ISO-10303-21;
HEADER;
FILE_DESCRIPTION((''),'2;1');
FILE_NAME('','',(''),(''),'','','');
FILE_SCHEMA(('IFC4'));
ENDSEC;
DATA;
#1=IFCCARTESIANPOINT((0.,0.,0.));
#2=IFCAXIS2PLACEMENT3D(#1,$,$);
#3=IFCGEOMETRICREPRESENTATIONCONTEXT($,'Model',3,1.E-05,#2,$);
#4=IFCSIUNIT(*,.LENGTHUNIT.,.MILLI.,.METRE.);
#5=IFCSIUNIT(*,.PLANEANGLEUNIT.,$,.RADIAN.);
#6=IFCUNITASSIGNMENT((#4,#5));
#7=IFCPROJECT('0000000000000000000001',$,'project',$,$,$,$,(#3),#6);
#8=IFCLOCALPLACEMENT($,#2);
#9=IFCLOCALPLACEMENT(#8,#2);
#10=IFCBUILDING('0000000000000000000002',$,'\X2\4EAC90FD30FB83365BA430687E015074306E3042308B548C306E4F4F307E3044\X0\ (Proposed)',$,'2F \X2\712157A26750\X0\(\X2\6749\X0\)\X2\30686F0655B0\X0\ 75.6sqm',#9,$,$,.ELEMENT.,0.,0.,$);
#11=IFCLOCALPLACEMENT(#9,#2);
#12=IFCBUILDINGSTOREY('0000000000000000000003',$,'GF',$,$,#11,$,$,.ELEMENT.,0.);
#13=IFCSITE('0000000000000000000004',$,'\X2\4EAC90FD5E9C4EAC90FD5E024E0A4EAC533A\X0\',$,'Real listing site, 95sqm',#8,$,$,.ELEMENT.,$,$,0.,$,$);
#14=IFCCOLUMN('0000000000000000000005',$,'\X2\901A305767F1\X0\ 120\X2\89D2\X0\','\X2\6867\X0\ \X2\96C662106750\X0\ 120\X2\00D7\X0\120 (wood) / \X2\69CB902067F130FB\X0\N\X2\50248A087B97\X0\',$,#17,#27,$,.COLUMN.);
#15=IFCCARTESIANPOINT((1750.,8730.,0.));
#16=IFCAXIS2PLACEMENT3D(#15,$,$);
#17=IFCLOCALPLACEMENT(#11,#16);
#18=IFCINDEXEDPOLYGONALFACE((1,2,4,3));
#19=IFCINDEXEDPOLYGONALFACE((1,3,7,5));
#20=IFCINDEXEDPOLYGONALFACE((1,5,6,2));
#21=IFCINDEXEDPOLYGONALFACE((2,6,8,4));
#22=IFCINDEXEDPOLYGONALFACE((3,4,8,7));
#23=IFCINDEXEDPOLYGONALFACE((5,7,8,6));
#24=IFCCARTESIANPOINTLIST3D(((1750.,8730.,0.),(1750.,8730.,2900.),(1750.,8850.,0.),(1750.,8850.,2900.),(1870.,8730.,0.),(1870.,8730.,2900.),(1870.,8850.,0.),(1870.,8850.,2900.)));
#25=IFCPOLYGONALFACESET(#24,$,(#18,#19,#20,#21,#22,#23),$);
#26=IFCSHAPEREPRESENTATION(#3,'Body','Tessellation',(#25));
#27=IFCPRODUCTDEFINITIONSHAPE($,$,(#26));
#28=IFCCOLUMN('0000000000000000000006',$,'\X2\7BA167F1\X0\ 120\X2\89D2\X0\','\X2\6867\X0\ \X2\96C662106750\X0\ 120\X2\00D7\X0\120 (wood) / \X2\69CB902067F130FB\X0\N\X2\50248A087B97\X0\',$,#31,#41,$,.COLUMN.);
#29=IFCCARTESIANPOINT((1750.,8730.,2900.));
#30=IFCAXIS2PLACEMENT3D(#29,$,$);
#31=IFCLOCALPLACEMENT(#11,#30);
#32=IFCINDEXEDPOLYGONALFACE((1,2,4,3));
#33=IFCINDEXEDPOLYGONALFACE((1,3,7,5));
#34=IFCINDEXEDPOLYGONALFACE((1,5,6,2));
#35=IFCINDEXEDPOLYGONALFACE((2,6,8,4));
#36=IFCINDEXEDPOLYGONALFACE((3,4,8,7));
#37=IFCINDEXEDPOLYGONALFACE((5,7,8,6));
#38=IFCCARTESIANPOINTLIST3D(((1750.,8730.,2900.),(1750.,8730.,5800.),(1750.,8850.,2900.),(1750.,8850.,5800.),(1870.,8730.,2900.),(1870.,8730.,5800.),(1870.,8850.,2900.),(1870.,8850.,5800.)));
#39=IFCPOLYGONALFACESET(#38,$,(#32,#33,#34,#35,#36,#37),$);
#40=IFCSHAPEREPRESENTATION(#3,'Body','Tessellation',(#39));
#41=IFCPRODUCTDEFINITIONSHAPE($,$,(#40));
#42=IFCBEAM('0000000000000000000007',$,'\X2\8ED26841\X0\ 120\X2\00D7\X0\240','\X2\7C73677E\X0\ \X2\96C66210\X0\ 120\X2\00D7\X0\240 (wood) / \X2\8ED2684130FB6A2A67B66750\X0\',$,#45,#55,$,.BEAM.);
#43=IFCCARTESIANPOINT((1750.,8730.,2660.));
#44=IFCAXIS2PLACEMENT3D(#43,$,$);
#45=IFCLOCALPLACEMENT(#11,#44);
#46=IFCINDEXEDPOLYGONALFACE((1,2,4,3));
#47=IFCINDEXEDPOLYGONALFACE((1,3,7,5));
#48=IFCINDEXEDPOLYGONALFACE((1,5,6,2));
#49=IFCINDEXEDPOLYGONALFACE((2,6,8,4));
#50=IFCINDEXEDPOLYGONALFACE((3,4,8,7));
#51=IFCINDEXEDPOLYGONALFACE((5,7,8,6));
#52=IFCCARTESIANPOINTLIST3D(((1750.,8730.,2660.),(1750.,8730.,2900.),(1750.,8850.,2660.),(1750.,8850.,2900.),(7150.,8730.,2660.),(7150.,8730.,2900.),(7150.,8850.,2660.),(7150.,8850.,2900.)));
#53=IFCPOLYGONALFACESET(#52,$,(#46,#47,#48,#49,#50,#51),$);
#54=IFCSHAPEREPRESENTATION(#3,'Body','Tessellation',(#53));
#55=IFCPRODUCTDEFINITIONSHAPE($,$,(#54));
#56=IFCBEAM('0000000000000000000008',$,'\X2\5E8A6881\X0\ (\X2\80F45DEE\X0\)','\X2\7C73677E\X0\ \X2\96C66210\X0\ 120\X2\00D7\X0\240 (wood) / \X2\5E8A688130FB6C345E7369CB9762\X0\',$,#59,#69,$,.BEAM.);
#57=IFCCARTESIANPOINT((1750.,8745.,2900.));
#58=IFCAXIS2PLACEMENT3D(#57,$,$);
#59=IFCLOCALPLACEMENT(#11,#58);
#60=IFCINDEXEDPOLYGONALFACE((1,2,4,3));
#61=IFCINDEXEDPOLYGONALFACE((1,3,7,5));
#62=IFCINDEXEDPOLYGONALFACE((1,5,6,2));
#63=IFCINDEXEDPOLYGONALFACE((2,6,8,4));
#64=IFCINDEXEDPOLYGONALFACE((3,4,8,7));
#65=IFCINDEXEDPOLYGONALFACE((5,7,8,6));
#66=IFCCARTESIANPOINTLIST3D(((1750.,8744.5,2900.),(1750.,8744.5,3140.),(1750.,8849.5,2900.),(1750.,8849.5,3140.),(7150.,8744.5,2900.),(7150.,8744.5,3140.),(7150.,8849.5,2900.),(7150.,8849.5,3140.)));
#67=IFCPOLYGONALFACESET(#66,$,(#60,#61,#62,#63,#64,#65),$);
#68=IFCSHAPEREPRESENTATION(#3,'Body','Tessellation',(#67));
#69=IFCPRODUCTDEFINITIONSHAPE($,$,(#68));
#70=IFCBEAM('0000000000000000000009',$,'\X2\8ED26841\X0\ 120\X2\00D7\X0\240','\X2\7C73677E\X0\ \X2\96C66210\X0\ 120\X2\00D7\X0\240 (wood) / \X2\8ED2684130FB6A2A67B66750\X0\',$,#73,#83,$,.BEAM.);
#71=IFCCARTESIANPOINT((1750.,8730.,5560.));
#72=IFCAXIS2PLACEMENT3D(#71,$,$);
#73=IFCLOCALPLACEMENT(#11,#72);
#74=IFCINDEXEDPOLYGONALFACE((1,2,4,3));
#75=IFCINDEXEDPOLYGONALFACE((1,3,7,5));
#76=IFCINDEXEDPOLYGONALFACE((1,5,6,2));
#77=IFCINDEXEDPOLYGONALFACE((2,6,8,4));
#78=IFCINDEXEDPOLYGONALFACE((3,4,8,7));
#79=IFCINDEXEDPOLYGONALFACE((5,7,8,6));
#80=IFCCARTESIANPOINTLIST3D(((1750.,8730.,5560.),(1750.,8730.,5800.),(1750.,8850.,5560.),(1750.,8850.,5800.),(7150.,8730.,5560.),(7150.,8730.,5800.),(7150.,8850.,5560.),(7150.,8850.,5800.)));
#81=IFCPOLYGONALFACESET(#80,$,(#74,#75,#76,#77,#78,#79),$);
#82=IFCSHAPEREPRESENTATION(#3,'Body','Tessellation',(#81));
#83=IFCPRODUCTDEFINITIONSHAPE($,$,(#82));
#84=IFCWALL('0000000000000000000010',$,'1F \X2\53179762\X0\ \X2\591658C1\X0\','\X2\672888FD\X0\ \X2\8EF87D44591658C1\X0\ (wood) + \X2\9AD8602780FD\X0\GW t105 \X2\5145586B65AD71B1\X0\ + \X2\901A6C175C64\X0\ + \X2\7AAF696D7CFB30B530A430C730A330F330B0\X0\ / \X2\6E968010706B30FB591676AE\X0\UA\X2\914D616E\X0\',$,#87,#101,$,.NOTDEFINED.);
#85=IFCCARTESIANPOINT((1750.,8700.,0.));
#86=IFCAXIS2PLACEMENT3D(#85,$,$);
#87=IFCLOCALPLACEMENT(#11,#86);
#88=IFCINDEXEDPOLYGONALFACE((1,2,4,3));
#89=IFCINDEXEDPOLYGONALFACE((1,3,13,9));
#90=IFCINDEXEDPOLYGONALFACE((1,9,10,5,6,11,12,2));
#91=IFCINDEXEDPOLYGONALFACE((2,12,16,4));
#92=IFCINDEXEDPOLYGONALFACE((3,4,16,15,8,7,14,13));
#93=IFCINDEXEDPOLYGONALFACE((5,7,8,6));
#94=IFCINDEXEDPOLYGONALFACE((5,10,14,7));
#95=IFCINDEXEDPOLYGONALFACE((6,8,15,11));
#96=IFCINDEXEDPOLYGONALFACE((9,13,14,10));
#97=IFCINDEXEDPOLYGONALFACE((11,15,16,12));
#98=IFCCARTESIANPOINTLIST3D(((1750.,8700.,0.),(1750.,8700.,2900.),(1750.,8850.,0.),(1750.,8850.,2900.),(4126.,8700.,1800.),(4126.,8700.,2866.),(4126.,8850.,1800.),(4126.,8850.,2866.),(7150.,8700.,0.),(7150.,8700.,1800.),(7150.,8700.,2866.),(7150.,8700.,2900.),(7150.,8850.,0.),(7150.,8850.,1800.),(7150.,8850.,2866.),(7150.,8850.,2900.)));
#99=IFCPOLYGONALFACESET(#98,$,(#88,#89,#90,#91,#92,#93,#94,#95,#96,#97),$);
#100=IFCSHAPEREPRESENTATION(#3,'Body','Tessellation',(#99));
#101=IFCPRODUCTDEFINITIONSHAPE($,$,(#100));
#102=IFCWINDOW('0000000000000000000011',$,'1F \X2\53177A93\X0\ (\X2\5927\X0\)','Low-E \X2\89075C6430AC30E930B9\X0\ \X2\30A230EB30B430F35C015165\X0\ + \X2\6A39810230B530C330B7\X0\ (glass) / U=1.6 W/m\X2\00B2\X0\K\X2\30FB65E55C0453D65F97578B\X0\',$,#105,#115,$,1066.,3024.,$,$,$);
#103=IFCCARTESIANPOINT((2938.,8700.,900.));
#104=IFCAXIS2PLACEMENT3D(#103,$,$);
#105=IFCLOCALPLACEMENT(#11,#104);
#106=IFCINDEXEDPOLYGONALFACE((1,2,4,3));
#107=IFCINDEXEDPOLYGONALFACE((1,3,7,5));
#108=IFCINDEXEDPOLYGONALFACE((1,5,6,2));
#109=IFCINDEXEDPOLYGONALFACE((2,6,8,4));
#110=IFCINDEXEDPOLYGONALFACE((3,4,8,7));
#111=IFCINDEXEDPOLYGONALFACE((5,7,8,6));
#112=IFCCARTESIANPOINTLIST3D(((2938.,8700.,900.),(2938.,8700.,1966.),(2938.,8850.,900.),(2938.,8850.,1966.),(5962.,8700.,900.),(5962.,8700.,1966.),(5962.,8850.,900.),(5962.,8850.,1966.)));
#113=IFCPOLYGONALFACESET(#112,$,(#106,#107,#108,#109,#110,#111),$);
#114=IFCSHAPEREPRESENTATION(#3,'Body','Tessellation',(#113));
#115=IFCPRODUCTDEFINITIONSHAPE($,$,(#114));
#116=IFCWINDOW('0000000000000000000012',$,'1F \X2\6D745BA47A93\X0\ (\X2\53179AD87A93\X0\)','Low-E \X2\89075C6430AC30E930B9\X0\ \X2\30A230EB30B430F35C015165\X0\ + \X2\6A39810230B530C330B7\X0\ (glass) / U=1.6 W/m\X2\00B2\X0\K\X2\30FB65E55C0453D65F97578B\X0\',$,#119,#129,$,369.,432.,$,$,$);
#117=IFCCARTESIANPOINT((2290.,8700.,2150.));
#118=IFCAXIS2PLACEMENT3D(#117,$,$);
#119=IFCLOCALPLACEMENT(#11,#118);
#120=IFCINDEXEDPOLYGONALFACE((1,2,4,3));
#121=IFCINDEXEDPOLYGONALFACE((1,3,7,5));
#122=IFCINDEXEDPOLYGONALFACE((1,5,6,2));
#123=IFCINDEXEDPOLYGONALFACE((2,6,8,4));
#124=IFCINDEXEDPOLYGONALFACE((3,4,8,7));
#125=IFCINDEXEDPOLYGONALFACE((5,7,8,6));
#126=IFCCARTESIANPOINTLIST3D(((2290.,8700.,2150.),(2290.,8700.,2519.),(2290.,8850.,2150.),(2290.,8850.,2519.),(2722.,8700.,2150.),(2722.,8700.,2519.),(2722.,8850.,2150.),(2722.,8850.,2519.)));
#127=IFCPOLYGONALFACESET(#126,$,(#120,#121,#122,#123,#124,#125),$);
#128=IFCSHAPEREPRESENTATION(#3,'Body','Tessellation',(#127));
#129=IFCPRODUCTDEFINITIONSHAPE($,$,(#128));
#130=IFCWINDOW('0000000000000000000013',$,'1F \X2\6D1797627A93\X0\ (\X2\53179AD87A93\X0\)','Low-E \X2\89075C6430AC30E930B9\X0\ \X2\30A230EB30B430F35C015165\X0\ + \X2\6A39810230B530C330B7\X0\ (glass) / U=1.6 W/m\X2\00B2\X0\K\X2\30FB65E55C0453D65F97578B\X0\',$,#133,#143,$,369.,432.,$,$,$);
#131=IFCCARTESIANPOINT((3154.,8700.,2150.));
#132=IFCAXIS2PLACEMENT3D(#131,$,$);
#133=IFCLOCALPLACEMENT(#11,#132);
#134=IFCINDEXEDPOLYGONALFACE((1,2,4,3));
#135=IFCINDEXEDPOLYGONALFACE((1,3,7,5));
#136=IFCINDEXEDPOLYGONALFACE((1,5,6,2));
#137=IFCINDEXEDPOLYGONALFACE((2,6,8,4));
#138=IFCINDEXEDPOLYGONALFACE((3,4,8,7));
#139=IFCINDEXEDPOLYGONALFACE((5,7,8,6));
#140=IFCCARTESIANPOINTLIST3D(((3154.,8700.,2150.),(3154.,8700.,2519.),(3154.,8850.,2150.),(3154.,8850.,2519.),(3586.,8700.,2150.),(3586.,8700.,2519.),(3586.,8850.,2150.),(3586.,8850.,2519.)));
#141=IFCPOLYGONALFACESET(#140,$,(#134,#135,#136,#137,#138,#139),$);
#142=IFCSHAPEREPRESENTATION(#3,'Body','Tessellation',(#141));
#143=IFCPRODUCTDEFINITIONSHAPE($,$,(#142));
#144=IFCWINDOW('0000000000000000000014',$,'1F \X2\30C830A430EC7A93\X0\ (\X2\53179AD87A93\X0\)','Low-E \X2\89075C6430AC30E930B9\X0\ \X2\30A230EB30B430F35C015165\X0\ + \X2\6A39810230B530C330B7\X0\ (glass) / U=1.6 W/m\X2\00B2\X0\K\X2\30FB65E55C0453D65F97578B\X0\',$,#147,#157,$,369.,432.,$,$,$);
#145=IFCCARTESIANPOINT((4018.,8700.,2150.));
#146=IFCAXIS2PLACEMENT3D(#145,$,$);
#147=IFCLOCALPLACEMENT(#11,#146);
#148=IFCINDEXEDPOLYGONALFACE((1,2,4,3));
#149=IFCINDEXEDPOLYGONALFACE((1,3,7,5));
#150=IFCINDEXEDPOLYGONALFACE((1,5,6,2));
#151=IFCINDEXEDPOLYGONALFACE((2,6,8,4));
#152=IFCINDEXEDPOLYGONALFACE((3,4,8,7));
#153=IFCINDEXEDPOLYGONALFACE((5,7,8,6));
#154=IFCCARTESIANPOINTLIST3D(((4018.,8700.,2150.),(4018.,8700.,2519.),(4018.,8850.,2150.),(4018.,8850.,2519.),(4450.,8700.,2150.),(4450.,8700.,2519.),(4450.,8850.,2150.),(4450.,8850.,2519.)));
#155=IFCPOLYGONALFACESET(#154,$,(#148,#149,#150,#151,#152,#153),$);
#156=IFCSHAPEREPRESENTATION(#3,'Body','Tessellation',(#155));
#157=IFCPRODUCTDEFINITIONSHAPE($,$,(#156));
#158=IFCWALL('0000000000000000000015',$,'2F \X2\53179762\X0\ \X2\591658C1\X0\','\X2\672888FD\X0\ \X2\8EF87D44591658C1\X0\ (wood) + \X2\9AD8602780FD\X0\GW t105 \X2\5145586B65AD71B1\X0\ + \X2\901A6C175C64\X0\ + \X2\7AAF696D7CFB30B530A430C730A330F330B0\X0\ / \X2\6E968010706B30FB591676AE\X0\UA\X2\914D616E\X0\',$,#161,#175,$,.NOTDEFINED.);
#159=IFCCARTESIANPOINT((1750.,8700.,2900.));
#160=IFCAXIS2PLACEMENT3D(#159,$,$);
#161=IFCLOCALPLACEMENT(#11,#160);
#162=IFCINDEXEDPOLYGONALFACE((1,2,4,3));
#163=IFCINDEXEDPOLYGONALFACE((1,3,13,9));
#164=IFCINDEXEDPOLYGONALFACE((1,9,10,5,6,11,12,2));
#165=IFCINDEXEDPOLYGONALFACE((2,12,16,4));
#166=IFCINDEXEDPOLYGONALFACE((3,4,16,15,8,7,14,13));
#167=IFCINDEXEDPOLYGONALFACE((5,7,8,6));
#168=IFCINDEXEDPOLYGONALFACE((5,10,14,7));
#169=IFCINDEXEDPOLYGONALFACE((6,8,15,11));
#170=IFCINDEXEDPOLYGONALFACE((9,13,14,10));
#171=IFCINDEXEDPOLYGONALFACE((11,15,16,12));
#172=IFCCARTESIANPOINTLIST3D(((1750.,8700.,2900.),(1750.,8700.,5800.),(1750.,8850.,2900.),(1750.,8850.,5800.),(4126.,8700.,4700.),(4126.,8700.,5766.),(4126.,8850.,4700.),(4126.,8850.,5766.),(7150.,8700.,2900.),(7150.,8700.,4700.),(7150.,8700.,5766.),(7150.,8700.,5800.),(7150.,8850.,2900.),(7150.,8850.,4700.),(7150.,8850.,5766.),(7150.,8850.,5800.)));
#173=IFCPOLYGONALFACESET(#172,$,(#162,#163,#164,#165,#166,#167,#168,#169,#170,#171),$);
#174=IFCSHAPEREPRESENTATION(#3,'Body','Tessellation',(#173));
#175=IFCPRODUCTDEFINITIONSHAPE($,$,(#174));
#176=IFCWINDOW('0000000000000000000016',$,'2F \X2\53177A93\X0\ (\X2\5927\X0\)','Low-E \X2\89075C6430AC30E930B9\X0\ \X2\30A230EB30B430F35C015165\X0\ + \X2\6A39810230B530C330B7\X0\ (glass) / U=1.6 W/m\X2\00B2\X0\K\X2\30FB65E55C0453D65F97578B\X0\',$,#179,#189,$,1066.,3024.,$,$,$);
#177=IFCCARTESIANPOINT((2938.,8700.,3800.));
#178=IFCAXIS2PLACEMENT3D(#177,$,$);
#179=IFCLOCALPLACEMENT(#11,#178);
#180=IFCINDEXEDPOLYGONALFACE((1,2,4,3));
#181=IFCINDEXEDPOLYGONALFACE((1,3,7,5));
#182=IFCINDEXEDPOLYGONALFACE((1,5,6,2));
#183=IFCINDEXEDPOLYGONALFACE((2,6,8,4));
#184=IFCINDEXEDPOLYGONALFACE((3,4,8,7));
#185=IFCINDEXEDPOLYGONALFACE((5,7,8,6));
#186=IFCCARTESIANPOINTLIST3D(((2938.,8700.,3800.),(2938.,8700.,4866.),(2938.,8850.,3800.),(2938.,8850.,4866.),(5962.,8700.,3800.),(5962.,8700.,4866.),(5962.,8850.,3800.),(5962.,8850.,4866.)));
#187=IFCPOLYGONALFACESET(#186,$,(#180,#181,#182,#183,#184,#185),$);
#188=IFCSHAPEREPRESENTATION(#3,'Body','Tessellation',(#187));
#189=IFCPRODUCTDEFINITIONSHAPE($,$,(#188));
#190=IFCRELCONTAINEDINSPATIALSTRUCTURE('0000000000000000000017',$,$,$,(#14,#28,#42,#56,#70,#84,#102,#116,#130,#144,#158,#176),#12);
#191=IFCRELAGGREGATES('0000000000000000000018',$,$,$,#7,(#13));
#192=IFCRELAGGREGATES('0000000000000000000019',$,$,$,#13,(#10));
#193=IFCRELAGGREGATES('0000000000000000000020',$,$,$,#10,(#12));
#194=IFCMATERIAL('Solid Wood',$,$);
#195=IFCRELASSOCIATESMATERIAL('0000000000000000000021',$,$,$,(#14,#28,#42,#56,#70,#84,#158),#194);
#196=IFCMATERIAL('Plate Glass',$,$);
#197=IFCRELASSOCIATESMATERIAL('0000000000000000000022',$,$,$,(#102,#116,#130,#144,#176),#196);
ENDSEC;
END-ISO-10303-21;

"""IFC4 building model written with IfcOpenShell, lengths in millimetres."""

from ifc_helpers import new_model, si_unit, frame, frame_2d, origin, place, context, project, spatial, rectangle, extrude, material, element, fill, save


model = new_model("IFC4")

# Units and contexts
model_context = context("Model", 3, precision=1e-05, world=origin())
ifc_project = project(units=[si_unit("LENGTHUNIT", "METRE", prefix="MILLI"), si_unit("PLANEANGLEUNIT", "RADIAN")], contexts=[model_context])

# Site, building, storey
site_placement = place(None, origin())
site = spatial("IfcSite", under=ifc_project, at=site_placement, Name="京都府京都市上京区", ObjectType="Real listing site, 95sqm", CompositionType="ELEMENT", RefElevation=0.0)
building_placement = place(site_placement, origin())
building = spatial("IfcBuilding", under=site, at=building_placement, Name="京都・茶室と縁側のある和の住まい (Proposed)", ObjectType="2F 無垢材(杉)と漆喰 75.6sqm", CompositionType="ELEMENT", ElevationOfRefHeight=0.0, ElevationOfTerrain=0.0)
storey_placement = place(building_placement, origin())
storey = spatial("IfcBuildingStorey", under=building, at=storey_placement, Name="GF", CompositionType="ELEMENT", Elevation=0.0)

# Columns
ifc_material_1 = material(Name="Solid Wood")
column_1_placement = place(storey_placement, frame((1750.0, 8730.0, 0.0)))
element("IfcColumn", 1, at=column_1_placement, inside=storey, material=ifc_material_1, Name="通し柱 120角", Description="桧 集成材 120×120 (wood) / 構造柱・N値計算", PredefinedType="COLUMN", context=model_context, shape_type="SweptSolid", body=[
    extrude(rectangle(XDim=120.0, YDim=120.0, at=frame_2d((60.0, 60.0))), frame((1750.0, 8730.0, 0.0)), (0.0, 0.0, 1.0), 2900.0),
])
column_2_placement = place(storey_placement, frame((1750.0, 8730.0, 2900.0)))
element("IfcColumn", 2, at=column_2_placement, inside=storey, material=ifc_material_1, Name="管柱 120角", Description="桧 集成材 120×120 (wood) / 構造柱・N値計算", PredefinedType="COLUMN", context=model_context, shape_type="SweptSolid", body=[
    extrude(rectangle(XDim=120.0, YDim=120.0, at=frame_2d((60.0, 60.0))), frame((1750.0, 8730.0, 2900.0)), (0.0, 0.0, 1.0), 2900.0),
])

# Beams
beam_1_placement = place(storey_placement, frame((1750.0, 8730.0, 2660.0)))
element("IfcBeam", 3, at=beam_1_placement, inside=storey, material=ifc_material_1, Name="軒桁 120×240", Description="米松 集成 120×240 (wood) / 軒桁・横架材", PredefinedType="BEAM", context=model_context, shape_type="SweptSolid", body=[
    extrude(rectangle(XDim=5400.0, YDim=120.0, at=frame_2d((2700.0, 60.0))), frame((1750.0, 8730.0, 2660.0)), (0.0, 0.0, 1.0), 240.0),
])
beam_2_placement = place(storey_placement, frame((1750.0, 8745.0, 2900.0)))
element("IfcBeam", 4, at=beam_2_placement, inside=storey, material=ifc_material_1, Name="床梁 (胴差)", Description="米松 集成 120×240 (wood) / 床梁・水平構面", PredefinedType="BEAM", context=model_context, shape_type="SweptSolid", body=[
    extrude(rectangle(XDim=5400.0, YDim=105.0, at=frame_2d((2700.0, 52.0))), frame((1750.0, 8745.0, 2900.0)), (0.0, 0.0, 1.0), 240.0),
])
beam_3_placement = place(storey_placement, frame((1750.0, 8730.0, 5560.0)))
element("IfcBeam", 5, at=beam_3_placement, inside=storey, material=ifc_material_1, Name="軒桁 120×240", Description="米松 集成 120×240 (wood) / 軒桁・横架材", PredefinedType="BEAM", context=model_context, shape_type="SweptSolid", body=[
    extrude(rectangle(XDim=5400.0, YDim=120.0, at=frame_2d((2700.0, 60.0))), frame((1750.0, 8730.0, 5560.0)), (0.0, 0.0, 1.0), 240.0),
])

# Wall, openings, windows
wall_1_placement = place(storey_placement, frame((1750.0, 8700.0, 0.0)))
wall_1 = element("IfcWall", 6, at=wall_1_placement, inside=storey, material=ifc_material_1, Name="1F 北面 外壁", Description="木製 軸組外壁 (wood) + 高性能GW t105 充填断熱 + 通気層 + 窯業系サイディング / 準耐火・外皮UA配慮", PredefinedType="NOTDEFINED", context=model_context, shape_type="SweptSolid", body=[
    extrude(rectangle(XDim=5400.0, YDim=150.0, at=frame_2d((2700.0, 75.0))), frame((1750.0, 8700.0, 0.0)), (0.0, 0.0, 1.0), 2900.0),
])
opening_1_placement = place(storey_placement, frame((2938.0, 8700.0, 900.0)))
opening_1 = element("IfcOpeningElement", 7, at=opening_1_placement, cuts=wall_1, PredefinedType="NOTDEFINED", context=model_context, shape_type="SweptSolid", body=[
    extrude(rectangle(XDim=3024.0, YDim=150.0, at=frame_2d((1512.0, 75.0))), frame((2938.0, 8700.0, 900.0)), (0.0, 0.0, 1.0), 1066.0),
])
opening_2_placement = place(storey_placement, frame((2290.0, 8700.0, 2150.0)))
opening_2 = element("IfcOpeningElement", 8, at=opening_2_placement, cuts=wall_1, PredefinedType="NOTDEFINED", context=model_context, shape_type="SweptSolid", body=[
    extrude(rectangle(XDim=432.0, YDim=150.0, at=frame_2d((216.0, 75.0))), frame((2290.0, 8700.0, 2150.0)), (0.0, 0.0, 1.0), 369.0),
])
opening_3_placement = place(storey_placement, frame((3154.0, 8700.0, 2150.0)))
opening_3 = element("IfcOpeningElement", 9, at=opening_3_placement, cuts=wall_1, PredefinedType="NOTDEFINED", context=model_context, shape_type="SweptSolid", body=[
    extrude(rectangle(XDim=432.0, YDim=150.0, at=frame_2d((216.0, 75.0))), frame((3154.0, 8700.0, 2150.0)), (0.0, 0.0, 1.0), 369.0),
])
opening_4_placement = place(storey_placement, frame((4018.0, 8700.0, 2150.0)))
opening_4 = element("IfcOpeningElement", 10, at=opening_4_placement, cuts=wall_1, PredefinedType="NOTDEFINED", context=model_context, shape_type="SweptSolid", body=[
    extrude(rectangle(XDim=432.0, YDim=150.0, at=frame_2d((216.0, 75.0))), frame((4018.0, 8700.0, 2150.0)), (0.0, 0.0, 1.0), 369.0),
])
ifc_material_2 = material(Name="Plate Glass")
window_1_placement = place(storey_placement, frame((2938.0, 8700.0, 900.0)))
window_1 = element("IfcWindow", 11, at=window_1_placement, inside=storey, material=ifc_material_2, Name="1F 北窓 (大)", Description="Low-E 複層ガラス アルゴン封入 + 樹脂サッシ (glass) / U=1.6 W/m²K・日射取得型", OverallHeight=1066.0, OverallWidth=3024.0, context=model_context, shape_type="SweptSolid", body=[
    extrude(rectangle(XDim=3024.0, YDim=150.0, at=frame_2d((1512.0, 75.0))), frame((2938.0, 8700.0, 900.0)), (0.0, 0.0, 1.0), 1066.0),
])
fill(opening_1, window_1)
window_2_placement = place(storey_placement, frame((2290.0, 8700.0, 2150.0)))
window_2 = element("IfcWindow", 12, at=window_2_placement, inside=storey, material=ifc_material_2, Name="1F 浴室窓 (北高窓)", Description="Low-E 複層ガラス アルゴン封入 + 樹脂サッシ (glass) / U=1.6 W/m²K・日射取得型", OverallHeight=369.0, OverallWidth=432.0, context=model_context, shape_type="SweptSolid", body=[
    extrude(rectangle(XDim=432.0, YDim=150.0, at=frame_2d((216.0, 75.0))), frame((2290.0, 8700.0, 2150.0)), (0.0, 0.0, 1.0), 369.0),
])
fill(opening_2, window_2)
window_3_placement = place(storey_placement, frame((3154.0, 8700.0, 2150.0)))
window_3 = element("IfcWindow", 13, at=window_3_placement, inside=storey, material=ifc_material_2, Name="1F 洗面窓 (北高窓)", Description="Low-E 複層ガラス アルゴン封入 + 樹脂サッシ (glass) / U=1.6 W/m²K・日射取得型", OverallHeight=369.0, OverallWidth=432.0, context=model_context, shape_type="SweptSolid", body=[
    extrude(rectangle(XDim=432.0, YDim=150.0, at=frame_2d((216.0, 75.0))), frame((3154.0, 8700.0, 2150.0)), (0.0, 0.0, 1.0), 369.0),
])
fill(opening_3, window_3)
window_4_placement = place(storey_placement, frame((4018.0, 8700.0, 2150.0)))
window_4 = element("IfcWindow", 14, at=window_4_placement, inside=storey, material=ifc_material_2, Name="1F トイレ窓 (北高窓)", Description="Low-E 複層ガラス アルゴン封入 + 樹脂サッシ (glass) / U=1.6 W/m²K・日射取得型", OverallHeight=369.0, OverallWidth=432.0, context=model_context, shape_type="SweptSolid", body=[
    extrude(rectangle(XDim=432.0, YDim=150.0, at=frame_2d((216.0, 75.0))), frame((4018.0, 8700.0, 2150.0)), (0.0, 0.0, 1.0), 369.0),
])
fill(opening_4, window_4)

# Wall, opening, window
wall_2_placement = place(storey_placement, frame((1750.0, 8700.0, 2900.0)))
wall_2 = element("IfcWall", 15, at=wall_2_placement, inside=storey, material=ifc_material_1, Name="2F 北面 外壁", Description="木製 軸組外壁 (wood) + 高性能GW t105 充填断熱 + 通気層 + 窯業系サイディング / 準耐火・外皮UA配慮", PredefinedType="NOTDEFINED", context=model_context, shape_type="SweptSolid", body=[
    extrude(rectangle(XDim=5400.0, YDim=150.0, at=frame_2d((2700.0, 75.0))), frame((1750.0, 8700.0, 2900.0)), (0.0, 0.0, 1.0), 2900.0),
])
opening_5_placement = place(storey_placement, frame((2938.0, 8700.0, 3800.0)))
opening_5 = element("IfcOpeningElement", 16, at=opening_5_placement, cuts=wall_2, PredefinedType="NOTDEFINED", context=model_context, shape_type="SweptSolid", body=[
    extrude(rectangle(XDim=3024.0, YDim=150.0, at=frame_2d((1512.0, 75.0))), frame((2938.0, 8700.0, 3800.0)), (0.0, 0.0, 1.0), 1066.0),
])
window_5_placement = place(storey_placement, frame((2938.0, 8700.0, 3800.0)))
window_5 = element("IfcWindow", 17, at=window_5_placement, inside=storey, material=ifc_material_2, Name="2F 北窓 (大)", Description="Low-E 複層ガラス アルゴン封入 + 樹脂サッシ (glass) / U=1.6 W/m²K・日射取得型", OverallHeight=1066.0, OverallWidth=3024.0, context=model_context, shape_type="SweptSolid", body=[
    extrude(rectangle(XDim=3024.0, YDim=150.0, at=frame_2d((1512.0, 75.0))), frame((2938.0, 8700.0, 3800.0)), (0.0, 0.0, 1.0), 1066.0),
])
fill(opening_5, window_5)

save(model, "model.ifc")
